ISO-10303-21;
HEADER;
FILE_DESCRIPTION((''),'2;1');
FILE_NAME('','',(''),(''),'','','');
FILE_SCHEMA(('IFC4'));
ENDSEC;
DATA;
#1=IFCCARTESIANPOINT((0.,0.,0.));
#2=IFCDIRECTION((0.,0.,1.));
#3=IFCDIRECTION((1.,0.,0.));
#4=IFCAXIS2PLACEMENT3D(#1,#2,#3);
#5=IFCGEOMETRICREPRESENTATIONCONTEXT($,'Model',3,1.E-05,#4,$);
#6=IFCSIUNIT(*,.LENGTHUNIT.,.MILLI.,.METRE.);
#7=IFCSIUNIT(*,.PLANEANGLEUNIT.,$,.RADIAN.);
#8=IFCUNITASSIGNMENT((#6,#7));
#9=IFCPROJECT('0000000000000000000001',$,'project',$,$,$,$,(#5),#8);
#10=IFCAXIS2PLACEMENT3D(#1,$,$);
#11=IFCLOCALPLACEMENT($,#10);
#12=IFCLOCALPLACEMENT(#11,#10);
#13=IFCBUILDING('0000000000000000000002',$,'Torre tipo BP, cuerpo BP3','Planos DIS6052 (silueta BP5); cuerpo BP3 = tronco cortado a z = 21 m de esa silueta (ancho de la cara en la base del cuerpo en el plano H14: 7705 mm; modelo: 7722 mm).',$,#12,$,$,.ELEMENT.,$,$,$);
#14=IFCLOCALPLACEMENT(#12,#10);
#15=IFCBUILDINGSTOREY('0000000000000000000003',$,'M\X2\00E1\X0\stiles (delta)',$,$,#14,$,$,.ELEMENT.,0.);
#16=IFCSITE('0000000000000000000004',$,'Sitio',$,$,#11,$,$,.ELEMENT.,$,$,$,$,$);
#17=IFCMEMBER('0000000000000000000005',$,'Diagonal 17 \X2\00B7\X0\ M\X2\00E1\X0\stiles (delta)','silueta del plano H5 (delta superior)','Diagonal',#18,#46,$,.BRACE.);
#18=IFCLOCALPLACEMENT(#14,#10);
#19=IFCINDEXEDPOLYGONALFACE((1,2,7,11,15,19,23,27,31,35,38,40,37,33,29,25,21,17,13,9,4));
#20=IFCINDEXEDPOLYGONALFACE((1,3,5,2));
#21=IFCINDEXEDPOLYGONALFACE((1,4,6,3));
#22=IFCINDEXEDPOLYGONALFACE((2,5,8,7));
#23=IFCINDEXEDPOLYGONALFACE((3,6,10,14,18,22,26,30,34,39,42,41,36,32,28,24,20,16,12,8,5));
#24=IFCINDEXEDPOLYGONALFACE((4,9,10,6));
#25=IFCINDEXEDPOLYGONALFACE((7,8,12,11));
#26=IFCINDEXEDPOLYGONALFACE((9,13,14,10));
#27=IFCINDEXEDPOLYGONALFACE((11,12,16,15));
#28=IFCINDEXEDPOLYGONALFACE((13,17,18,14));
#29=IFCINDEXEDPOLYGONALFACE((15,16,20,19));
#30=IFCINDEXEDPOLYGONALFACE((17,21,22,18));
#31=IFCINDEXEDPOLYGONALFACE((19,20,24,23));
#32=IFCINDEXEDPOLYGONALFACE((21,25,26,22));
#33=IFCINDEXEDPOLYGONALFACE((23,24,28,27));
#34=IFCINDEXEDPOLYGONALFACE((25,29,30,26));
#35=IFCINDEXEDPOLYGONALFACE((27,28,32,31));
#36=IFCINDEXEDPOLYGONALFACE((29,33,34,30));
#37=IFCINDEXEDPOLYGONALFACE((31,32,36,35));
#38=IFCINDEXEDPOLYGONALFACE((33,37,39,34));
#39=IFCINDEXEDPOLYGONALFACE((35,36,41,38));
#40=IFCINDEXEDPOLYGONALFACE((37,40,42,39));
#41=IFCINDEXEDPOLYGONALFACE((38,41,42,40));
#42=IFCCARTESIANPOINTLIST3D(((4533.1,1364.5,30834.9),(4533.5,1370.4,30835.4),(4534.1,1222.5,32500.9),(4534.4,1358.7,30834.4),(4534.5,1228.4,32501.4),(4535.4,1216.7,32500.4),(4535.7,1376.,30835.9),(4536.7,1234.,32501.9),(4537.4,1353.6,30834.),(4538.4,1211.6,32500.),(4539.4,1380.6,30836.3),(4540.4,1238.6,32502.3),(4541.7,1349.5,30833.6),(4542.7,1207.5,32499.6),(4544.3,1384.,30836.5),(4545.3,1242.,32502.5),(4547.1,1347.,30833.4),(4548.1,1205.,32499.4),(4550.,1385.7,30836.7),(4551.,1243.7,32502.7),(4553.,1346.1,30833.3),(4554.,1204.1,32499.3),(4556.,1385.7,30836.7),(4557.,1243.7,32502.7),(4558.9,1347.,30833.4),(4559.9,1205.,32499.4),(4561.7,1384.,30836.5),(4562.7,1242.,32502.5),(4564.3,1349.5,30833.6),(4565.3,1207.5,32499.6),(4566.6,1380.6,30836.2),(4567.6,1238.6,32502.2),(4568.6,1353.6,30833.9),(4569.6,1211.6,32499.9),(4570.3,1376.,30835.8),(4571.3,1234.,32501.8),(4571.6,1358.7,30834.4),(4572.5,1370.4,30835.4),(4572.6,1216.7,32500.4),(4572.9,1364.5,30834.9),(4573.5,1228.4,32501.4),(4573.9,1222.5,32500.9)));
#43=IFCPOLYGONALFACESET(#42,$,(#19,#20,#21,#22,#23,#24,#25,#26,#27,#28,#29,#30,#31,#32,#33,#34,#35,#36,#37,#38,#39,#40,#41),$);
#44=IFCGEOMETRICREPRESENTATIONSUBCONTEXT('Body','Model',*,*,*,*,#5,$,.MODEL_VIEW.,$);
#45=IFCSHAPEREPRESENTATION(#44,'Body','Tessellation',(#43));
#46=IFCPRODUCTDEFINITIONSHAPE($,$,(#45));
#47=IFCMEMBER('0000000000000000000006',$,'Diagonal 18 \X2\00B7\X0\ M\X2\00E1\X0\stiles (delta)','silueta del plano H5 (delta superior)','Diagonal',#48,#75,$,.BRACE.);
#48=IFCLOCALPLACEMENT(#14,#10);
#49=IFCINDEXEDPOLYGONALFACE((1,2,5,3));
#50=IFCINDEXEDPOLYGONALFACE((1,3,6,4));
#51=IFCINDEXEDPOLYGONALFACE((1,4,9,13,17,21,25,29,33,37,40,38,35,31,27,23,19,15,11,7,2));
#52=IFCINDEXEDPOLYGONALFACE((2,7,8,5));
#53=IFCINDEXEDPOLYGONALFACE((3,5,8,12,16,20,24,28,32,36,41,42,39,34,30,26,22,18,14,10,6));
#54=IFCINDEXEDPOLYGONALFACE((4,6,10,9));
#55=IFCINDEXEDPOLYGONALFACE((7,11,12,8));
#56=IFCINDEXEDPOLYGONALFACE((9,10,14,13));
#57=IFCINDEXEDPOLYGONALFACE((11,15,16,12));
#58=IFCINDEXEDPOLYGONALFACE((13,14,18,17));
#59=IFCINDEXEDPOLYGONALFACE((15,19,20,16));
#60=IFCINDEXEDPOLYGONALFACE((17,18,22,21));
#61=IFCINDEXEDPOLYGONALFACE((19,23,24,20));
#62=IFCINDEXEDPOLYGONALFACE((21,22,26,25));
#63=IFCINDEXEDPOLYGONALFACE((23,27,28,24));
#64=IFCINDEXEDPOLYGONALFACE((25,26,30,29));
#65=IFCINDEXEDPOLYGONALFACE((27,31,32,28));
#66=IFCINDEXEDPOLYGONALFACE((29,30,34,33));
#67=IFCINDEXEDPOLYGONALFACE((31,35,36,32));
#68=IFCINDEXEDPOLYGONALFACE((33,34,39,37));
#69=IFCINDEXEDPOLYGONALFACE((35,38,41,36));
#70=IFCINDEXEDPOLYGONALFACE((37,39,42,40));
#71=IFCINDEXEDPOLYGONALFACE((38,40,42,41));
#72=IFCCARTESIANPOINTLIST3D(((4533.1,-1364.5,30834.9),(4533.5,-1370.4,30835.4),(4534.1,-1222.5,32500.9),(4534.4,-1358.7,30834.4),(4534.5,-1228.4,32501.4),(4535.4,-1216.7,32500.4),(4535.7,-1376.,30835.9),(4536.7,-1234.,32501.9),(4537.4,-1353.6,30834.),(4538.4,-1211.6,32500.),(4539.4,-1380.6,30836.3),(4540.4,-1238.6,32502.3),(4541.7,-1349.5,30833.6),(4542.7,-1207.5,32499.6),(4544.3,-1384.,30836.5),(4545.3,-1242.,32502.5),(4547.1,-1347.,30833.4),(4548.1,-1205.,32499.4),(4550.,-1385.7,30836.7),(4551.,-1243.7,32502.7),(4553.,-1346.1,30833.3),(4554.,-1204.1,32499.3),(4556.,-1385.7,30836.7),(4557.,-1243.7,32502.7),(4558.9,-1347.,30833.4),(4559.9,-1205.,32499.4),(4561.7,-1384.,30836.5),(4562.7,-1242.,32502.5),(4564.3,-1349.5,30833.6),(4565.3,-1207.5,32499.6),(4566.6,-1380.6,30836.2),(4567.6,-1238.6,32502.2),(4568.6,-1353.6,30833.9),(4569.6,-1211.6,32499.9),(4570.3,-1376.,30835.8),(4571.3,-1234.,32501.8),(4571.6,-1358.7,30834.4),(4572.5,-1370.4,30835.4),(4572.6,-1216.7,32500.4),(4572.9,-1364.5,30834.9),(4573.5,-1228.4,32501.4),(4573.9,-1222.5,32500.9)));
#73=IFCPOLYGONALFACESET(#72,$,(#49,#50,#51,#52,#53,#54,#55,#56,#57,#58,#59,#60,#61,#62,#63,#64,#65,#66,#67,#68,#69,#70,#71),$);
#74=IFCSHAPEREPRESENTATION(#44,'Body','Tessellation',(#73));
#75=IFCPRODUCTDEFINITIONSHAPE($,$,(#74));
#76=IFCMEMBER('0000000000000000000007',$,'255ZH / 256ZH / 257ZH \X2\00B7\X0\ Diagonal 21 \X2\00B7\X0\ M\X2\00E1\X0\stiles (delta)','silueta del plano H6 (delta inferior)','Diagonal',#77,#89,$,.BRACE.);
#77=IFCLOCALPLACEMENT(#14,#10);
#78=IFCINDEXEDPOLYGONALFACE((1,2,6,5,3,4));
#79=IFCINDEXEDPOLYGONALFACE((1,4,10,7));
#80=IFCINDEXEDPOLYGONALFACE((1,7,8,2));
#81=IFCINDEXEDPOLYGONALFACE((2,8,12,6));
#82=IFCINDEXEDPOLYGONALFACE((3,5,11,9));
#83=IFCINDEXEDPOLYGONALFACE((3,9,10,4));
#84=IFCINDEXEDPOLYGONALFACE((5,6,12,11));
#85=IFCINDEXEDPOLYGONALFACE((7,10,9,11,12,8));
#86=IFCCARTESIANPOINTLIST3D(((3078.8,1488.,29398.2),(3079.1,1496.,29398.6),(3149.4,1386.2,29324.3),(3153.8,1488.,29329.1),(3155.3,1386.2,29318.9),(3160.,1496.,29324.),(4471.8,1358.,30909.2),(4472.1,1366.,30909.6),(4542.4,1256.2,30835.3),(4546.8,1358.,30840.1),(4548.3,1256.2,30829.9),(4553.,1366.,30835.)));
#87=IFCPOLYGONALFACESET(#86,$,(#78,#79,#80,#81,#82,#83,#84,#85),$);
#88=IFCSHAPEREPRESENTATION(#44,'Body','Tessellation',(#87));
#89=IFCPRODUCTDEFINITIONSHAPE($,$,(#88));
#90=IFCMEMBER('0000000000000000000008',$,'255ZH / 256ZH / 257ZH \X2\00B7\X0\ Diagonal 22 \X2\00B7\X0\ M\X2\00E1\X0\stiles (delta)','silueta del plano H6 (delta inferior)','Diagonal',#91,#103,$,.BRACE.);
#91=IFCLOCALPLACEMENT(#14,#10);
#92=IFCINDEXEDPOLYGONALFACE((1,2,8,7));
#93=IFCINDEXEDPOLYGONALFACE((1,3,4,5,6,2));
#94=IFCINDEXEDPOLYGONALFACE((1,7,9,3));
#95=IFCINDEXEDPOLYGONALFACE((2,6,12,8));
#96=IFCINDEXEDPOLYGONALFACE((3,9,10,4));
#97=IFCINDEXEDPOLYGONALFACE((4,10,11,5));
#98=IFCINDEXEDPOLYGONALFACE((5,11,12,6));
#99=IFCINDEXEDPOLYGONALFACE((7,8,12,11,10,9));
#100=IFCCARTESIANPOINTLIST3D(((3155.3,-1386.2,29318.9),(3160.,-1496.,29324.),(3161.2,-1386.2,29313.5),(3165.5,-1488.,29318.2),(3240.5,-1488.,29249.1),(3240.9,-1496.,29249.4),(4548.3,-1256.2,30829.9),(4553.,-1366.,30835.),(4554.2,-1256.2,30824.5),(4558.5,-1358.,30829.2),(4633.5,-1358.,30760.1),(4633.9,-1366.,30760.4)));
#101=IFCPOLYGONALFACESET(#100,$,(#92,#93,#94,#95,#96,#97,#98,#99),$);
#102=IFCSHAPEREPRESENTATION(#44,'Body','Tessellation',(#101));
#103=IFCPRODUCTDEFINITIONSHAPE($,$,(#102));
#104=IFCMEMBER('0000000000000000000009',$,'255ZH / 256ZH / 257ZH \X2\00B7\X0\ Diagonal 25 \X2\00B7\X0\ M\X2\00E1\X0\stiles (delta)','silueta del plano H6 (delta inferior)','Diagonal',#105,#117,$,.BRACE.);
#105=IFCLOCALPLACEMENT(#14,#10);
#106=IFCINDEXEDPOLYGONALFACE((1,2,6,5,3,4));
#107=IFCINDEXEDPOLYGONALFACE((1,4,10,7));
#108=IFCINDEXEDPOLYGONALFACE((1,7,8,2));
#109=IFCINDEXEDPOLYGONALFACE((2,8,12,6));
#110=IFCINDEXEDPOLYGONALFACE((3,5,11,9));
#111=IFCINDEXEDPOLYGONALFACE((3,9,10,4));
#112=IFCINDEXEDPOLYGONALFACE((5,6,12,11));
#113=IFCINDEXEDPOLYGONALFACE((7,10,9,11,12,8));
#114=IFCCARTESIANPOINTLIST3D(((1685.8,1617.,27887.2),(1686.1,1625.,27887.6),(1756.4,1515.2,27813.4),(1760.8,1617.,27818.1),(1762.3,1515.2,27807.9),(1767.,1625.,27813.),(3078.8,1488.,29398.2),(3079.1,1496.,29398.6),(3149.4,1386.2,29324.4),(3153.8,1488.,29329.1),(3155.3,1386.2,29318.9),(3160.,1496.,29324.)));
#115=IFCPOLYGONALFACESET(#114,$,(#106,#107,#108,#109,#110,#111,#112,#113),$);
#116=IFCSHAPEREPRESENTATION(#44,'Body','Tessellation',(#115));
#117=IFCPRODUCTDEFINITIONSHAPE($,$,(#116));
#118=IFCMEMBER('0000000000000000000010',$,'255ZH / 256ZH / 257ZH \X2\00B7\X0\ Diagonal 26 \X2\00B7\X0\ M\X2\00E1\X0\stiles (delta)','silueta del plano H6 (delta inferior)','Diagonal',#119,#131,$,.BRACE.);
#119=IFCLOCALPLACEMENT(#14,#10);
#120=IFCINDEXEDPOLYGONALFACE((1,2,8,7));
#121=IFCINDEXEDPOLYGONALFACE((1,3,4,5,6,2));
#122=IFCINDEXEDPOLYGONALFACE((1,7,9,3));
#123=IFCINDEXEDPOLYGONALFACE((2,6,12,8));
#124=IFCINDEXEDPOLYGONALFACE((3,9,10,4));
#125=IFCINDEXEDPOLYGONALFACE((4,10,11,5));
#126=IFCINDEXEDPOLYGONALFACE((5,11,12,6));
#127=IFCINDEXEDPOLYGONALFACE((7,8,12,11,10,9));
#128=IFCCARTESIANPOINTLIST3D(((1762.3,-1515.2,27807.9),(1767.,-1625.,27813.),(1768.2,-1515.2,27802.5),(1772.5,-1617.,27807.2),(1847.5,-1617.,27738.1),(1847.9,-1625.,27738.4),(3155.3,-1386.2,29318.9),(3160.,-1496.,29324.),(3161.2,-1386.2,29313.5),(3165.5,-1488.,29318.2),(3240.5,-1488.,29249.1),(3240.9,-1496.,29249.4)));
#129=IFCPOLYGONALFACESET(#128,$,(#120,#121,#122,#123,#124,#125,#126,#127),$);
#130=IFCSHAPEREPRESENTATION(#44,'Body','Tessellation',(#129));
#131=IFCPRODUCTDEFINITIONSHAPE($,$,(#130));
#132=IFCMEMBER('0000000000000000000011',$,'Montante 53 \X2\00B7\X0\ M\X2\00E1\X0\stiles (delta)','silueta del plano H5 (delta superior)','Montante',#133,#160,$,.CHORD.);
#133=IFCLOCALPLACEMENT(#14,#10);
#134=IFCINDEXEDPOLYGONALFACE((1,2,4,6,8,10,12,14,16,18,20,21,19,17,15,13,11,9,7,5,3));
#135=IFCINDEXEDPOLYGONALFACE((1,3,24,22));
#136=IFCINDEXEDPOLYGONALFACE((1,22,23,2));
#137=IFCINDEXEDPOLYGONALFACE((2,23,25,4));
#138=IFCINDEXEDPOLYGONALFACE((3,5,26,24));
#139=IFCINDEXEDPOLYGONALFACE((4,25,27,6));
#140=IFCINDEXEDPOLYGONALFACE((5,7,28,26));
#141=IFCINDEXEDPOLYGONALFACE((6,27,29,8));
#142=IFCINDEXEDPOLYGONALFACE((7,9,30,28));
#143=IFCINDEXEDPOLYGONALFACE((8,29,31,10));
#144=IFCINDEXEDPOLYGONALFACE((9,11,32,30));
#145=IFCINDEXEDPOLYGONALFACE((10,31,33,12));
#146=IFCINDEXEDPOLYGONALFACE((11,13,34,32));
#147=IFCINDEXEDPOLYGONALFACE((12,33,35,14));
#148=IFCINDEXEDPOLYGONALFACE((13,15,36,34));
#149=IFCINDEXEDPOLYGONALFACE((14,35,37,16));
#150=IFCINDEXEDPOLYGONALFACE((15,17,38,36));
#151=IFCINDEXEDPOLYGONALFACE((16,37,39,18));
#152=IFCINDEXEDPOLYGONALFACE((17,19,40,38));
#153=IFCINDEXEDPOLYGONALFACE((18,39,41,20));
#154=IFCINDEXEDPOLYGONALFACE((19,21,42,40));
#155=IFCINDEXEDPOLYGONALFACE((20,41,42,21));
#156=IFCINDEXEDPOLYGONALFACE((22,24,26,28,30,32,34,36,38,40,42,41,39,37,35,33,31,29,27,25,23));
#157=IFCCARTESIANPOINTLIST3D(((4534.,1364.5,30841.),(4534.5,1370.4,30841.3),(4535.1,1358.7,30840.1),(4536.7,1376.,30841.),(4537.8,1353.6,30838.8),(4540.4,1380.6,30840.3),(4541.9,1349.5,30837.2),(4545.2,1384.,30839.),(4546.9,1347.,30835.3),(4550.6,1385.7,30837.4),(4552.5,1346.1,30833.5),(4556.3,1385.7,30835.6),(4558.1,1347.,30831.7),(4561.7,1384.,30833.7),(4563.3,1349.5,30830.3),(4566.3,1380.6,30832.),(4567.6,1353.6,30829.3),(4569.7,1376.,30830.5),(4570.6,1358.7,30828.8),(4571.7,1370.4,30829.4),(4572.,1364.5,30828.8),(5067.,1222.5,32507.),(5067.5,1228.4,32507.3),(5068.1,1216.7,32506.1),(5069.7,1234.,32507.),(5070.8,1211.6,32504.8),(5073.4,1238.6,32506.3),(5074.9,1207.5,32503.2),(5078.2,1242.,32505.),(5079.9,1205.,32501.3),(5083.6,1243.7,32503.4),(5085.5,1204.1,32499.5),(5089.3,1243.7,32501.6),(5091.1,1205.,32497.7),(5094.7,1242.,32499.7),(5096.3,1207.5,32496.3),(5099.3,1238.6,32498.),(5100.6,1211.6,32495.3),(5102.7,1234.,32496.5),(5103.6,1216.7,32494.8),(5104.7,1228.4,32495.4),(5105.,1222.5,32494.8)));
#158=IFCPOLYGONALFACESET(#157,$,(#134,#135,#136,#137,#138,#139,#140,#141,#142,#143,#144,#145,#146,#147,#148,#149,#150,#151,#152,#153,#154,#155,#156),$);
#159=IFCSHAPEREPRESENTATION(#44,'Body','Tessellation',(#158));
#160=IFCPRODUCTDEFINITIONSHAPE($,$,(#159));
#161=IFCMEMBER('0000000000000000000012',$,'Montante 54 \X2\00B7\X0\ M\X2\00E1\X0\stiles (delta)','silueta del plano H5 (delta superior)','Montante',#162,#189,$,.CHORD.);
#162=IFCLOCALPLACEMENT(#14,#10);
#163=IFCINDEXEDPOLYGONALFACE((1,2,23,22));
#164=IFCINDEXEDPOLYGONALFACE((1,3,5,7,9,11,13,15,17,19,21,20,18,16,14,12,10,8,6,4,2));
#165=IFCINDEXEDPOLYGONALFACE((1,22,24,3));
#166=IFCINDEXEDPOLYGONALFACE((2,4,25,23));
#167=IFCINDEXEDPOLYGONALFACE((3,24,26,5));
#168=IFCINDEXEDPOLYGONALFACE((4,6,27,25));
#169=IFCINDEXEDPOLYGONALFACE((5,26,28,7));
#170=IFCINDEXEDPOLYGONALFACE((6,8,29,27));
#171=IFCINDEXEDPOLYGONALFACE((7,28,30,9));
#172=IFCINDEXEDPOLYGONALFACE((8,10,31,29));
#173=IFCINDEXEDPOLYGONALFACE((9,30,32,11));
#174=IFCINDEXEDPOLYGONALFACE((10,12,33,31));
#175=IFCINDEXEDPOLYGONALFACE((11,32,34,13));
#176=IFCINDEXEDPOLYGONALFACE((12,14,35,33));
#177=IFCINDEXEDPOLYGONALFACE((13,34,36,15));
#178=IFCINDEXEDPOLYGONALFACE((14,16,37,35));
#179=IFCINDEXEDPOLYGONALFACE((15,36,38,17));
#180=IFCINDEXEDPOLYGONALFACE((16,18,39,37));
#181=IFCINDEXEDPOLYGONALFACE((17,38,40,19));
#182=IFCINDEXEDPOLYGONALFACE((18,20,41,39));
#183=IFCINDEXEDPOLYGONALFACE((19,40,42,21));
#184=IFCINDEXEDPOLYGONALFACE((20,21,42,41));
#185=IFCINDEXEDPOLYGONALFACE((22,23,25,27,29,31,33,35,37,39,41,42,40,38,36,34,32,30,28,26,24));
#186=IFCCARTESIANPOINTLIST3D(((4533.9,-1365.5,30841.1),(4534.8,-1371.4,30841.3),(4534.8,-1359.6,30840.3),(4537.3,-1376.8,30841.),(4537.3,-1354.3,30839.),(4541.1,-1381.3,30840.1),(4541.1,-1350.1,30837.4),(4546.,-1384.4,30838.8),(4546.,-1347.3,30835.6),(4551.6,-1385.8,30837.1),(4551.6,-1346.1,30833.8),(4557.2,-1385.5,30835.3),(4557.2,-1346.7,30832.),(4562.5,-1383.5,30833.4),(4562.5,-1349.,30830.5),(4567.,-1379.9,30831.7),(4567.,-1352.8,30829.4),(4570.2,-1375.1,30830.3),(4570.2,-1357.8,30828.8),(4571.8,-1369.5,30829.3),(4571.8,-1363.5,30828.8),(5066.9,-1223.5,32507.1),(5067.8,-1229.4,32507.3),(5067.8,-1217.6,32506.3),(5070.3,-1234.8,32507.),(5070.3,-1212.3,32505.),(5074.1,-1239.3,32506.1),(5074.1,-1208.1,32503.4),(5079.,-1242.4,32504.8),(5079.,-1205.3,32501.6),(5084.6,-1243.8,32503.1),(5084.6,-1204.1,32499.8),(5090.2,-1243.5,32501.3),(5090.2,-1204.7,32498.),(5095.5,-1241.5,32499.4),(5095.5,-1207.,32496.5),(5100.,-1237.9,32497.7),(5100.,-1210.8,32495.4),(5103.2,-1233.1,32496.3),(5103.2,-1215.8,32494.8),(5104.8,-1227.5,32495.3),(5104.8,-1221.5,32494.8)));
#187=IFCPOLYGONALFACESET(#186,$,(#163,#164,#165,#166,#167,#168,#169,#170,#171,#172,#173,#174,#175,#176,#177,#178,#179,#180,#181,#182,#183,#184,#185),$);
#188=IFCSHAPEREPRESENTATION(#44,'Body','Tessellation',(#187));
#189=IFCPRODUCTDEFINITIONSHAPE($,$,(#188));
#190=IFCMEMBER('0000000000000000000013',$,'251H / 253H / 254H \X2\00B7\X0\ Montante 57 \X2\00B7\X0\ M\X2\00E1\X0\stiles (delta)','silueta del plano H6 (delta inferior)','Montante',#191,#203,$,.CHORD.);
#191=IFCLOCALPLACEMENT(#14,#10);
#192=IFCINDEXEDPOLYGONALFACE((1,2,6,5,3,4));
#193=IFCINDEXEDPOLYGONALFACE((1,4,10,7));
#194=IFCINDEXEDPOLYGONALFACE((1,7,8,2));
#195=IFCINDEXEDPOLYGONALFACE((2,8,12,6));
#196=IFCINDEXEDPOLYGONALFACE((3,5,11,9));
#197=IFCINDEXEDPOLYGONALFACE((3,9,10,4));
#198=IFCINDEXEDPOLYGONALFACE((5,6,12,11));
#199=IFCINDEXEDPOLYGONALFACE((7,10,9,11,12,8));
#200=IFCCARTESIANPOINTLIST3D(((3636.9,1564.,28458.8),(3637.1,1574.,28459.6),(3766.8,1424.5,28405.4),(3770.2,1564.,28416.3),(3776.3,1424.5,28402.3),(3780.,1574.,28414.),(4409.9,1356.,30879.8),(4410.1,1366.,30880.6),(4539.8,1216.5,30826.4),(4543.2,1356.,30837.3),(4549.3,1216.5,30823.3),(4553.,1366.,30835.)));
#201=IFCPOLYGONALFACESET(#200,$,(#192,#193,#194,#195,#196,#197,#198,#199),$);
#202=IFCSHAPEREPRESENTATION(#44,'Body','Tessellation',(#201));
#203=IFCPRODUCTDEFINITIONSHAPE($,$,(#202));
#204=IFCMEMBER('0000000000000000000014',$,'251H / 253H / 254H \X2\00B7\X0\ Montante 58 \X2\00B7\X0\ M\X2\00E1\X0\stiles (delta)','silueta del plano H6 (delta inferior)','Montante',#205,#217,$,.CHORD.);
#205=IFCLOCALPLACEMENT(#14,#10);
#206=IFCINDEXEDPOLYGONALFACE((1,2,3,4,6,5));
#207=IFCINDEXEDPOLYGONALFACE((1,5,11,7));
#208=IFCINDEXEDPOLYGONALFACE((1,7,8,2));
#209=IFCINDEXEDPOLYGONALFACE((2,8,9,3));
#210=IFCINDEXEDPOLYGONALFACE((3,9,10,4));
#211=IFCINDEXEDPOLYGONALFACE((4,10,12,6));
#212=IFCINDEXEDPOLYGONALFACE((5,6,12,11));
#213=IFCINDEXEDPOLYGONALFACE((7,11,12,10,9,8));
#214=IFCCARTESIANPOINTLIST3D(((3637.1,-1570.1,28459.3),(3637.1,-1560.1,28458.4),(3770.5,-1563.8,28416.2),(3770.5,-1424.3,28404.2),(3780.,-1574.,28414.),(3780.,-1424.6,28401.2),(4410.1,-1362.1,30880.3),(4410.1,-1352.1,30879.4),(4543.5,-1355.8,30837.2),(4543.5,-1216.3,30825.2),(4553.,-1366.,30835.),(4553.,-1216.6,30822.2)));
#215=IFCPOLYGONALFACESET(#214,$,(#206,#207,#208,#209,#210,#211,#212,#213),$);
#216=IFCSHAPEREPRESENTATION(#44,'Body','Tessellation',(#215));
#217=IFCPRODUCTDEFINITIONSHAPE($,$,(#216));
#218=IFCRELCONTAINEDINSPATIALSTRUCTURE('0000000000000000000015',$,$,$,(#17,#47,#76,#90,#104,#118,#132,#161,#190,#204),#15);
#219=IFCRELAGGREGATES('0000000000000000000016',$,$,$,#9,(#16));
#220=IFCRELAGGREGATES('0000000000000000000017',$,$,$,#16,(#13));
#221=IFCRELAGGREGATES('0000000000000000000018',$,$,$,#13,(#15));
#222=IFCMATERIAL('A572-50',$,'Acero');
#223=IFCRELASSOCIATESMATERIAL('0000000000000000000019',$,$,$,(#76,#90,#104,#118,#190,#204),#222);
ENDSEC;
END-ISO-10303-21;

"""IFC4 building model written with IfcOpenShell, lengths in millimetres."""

from ifc_helpers import new_model, si_unit, frame, frame_2d, origin, origin_with_axes, place, context, subcontext, project, spatial, circle, l_section, extrude, material, element, save


model = new_model("IFC4")

# Units and contexts
model_context = context("Model", 3, precision=1e-05, world=origin_with_axes())
body_context = subcontext(model_context, "Body", "Model", "MODEL_VIEW")
ifc_project = project(units=[si_unit("LENGTHUNIT", "METRE", prefix="MILLI"), si_unit("PLANEANGLEUNIT", "RADIAN")], contexts=[model_context])

# Site, building, storey
site_placement = place(None, origin())
site = spatial("IfcSite", under=ifc_project, at=site_placement, Name="Sitio", CompositionType="ELEMENT")
building_placement = place(site_placement, origin())
building = spatial("IfcBuilding", under=site, at=building_placement, Name="Torre tipo BP, cuerpo BP3", Description="Planos DIS6052 (silueta BP5); cuerpo BP3 = tronco cortado a z = 21 m de esa silueta (ancho de la cara en la base del cuerpo en el plano H14: 7705 mm; modelo: 7722 mm).", CompositionType="ELEMENT")
storey_placement = place(building_placement, origin())
storey = spatial("IfcBuildingStorey", under=building, at=storey_placement, Name="Mástiles (delta)", CompositionType="ELEMENT", Elevation=0.0)

# Members
for number, where, z_axis, x_axis, name in (
    (1, (4554.0, 1224.0, 32501.0), (-0.000598, 0.084926, -0.996387), (-0.000051, -0.996387, -0.084926), "Diagonal 17 · Mástiles (delta)"),
    (2, (4554.0, -1224.0, 32501.0), (-0.000598, -0.084926, -0.996387), (-0.000051, 0.996387, -0.084926), "Diagonal 18 · Mástiles (delta)"),
):
    element("IfcMember", number, at=place(storey_placement, frame(where, z_axis=z_axis, x_axis=x_axis)), inside=storey, Name=name, Description="silueta del plano H5 (delta superior)", ObjectType="Diagonal", PredefinedType="BRACE", context=body_context, shape_type="SweptSolid", body=[
        extrude(circle(Radius=20.0), None, (0.0, 0.0, 1.0), 1672.0),
    ])
ifc_material = material(Name="A572-50", Category="Acero")
for number, where, z_axis, x_axis, name in (
    (3, (4553.0, 1366.0, 30835.0), (-0.676463, 0.06313, -0.733766), (-0.042791, -0.998005, -0.046415), "255ZH / 256ZH / 257ZH · Diagonal 21 · Mástiles (delta)"),
    (4, (4553.0, -1366.0, 30835.0), (-0.676463, -0.06313, -0.733766), (-0.042791, 0.998005, -0.046415), "255ZH / 256ZH / 257ZH · Diagonal 22 · Mástiles (delta)"),
):
    element("IfcMember", number, at=place(storey_placement, frame(where, z_axis=z_axis, x_axis=x_axis)), inside=storey, material=ifc_material, Name=name, Description="silueta del plano H6 (delta inferior)", ObjectType="Diagonal", PredefinedType="BRACE", context=body_context, shape_type="SweptSolid", body=[
        extrude(l_section(Depth=110.0, Width=110.0, Thickness=8.0, at=frame_2d((55.0, 55.0))), None, (0.0, 0.0, 1.0), 2059.2),
    ])
for number, where, z_axis, x_axis, name in (
    (5, (3160.0, 1496.0, 29324.0), (-0.676484, 0.062646, -0.733788), (-0.042463, -0.998036, -0.04606), "255ZH / 256ZH / 257ZH · Diagonal 25 · Mástiles (delta)"),
    (6, (3160.0, -1496.0, 29324.0), (-0.676484, -0.062646, -0.733788), (-0.042463, 0.998036, -0.04606), "255ZH / 256ZH / 257ZH · Diagonal 26 · Mástiles (delta)"),
):
    element("IfcMember", number, at=place(storey_placement, frame(where, z_axis=z_axis, x_axis=x_axis)), inside=storey, material=ifc_material, Name=name, Description="silueta del plano H6 (delta inferior)", ObjectType="Diagonal", PredefinedType="BRACE", context=body_context, shape_type="SweptSolid", body=[
        extrude(l_section(Depth=110.0, Width=110.0, Thickness=8.0, at=frame_2d((55.0, 55.0))), None, (0.0, 0.0, 1.0), 2059.2),
    ])
for number, where, z_axis, x_axis, name in (
    (7, (5086.0, 1224.0, 32501.0), (-0.303714, 0.080915, -0.949321), (-0.024656, -0.996721, -0.077067), "Montante 53 · Mástiles (delta)"),
    (8, (5086.0, -1224.0, 32501.0), (-0.303714, -0.080915, -0.949321), (-0.952763, 0.025793, 0.302617), "Montante 54 · Mástiles (delta)"),
):
    element("IfcMember", number, at=place(storey_placement, frame(where, z_axis=z_axis, x_axis=x_axis)), inside=storey, Name=name, Description="silueta del plano H5 (delta superior)", ObjectType="Montante", PredefinedType="CHORD", context=body_context, shape_type="SweptSolid", body=[
        extrude(circle(Radius=20.0), None, (0.0, 0.0, 1.0), 1754.9),
    ])
for number, where, z_axis, x_axis, name in (
    (9, (4553.0, 1366.0, 30835.0), (-0.303148, 0.081572, -0.949446), (-0.024811, -0.996667, -0.077707), "251H / 253H / 254H · Montante 57 · Mástiles (delta)"),
    (10, (4553.0, -1366.0, 30835.0), (-0.303148, -0.081572, -0.949446), (-0.952943, 0.025949, 0.302035), "251H / 253H / 254H · Montante 58 · Mástiles (delta)"),
):
    element("IfcMember", number, at=place(storey_placement, frame(where, z_axis=z_axis, x_axis=x_axis)), inside=storey, material=ifc_material, Name=name, Description="silueta del plano H6 (delta inferior)", ObjectType="Montante", PredefinedType="CHORD", context=body_context, shape_type="SweptSolid", body=[
        extrude(l_section(Depth=150.0, Width=150.0, Thickness=10.0, at=frame_2d((75.0, 75.0))), None, (0.0, 0.0, 1.0), 2549.9),
    ])

save(model, "model.ifc")
